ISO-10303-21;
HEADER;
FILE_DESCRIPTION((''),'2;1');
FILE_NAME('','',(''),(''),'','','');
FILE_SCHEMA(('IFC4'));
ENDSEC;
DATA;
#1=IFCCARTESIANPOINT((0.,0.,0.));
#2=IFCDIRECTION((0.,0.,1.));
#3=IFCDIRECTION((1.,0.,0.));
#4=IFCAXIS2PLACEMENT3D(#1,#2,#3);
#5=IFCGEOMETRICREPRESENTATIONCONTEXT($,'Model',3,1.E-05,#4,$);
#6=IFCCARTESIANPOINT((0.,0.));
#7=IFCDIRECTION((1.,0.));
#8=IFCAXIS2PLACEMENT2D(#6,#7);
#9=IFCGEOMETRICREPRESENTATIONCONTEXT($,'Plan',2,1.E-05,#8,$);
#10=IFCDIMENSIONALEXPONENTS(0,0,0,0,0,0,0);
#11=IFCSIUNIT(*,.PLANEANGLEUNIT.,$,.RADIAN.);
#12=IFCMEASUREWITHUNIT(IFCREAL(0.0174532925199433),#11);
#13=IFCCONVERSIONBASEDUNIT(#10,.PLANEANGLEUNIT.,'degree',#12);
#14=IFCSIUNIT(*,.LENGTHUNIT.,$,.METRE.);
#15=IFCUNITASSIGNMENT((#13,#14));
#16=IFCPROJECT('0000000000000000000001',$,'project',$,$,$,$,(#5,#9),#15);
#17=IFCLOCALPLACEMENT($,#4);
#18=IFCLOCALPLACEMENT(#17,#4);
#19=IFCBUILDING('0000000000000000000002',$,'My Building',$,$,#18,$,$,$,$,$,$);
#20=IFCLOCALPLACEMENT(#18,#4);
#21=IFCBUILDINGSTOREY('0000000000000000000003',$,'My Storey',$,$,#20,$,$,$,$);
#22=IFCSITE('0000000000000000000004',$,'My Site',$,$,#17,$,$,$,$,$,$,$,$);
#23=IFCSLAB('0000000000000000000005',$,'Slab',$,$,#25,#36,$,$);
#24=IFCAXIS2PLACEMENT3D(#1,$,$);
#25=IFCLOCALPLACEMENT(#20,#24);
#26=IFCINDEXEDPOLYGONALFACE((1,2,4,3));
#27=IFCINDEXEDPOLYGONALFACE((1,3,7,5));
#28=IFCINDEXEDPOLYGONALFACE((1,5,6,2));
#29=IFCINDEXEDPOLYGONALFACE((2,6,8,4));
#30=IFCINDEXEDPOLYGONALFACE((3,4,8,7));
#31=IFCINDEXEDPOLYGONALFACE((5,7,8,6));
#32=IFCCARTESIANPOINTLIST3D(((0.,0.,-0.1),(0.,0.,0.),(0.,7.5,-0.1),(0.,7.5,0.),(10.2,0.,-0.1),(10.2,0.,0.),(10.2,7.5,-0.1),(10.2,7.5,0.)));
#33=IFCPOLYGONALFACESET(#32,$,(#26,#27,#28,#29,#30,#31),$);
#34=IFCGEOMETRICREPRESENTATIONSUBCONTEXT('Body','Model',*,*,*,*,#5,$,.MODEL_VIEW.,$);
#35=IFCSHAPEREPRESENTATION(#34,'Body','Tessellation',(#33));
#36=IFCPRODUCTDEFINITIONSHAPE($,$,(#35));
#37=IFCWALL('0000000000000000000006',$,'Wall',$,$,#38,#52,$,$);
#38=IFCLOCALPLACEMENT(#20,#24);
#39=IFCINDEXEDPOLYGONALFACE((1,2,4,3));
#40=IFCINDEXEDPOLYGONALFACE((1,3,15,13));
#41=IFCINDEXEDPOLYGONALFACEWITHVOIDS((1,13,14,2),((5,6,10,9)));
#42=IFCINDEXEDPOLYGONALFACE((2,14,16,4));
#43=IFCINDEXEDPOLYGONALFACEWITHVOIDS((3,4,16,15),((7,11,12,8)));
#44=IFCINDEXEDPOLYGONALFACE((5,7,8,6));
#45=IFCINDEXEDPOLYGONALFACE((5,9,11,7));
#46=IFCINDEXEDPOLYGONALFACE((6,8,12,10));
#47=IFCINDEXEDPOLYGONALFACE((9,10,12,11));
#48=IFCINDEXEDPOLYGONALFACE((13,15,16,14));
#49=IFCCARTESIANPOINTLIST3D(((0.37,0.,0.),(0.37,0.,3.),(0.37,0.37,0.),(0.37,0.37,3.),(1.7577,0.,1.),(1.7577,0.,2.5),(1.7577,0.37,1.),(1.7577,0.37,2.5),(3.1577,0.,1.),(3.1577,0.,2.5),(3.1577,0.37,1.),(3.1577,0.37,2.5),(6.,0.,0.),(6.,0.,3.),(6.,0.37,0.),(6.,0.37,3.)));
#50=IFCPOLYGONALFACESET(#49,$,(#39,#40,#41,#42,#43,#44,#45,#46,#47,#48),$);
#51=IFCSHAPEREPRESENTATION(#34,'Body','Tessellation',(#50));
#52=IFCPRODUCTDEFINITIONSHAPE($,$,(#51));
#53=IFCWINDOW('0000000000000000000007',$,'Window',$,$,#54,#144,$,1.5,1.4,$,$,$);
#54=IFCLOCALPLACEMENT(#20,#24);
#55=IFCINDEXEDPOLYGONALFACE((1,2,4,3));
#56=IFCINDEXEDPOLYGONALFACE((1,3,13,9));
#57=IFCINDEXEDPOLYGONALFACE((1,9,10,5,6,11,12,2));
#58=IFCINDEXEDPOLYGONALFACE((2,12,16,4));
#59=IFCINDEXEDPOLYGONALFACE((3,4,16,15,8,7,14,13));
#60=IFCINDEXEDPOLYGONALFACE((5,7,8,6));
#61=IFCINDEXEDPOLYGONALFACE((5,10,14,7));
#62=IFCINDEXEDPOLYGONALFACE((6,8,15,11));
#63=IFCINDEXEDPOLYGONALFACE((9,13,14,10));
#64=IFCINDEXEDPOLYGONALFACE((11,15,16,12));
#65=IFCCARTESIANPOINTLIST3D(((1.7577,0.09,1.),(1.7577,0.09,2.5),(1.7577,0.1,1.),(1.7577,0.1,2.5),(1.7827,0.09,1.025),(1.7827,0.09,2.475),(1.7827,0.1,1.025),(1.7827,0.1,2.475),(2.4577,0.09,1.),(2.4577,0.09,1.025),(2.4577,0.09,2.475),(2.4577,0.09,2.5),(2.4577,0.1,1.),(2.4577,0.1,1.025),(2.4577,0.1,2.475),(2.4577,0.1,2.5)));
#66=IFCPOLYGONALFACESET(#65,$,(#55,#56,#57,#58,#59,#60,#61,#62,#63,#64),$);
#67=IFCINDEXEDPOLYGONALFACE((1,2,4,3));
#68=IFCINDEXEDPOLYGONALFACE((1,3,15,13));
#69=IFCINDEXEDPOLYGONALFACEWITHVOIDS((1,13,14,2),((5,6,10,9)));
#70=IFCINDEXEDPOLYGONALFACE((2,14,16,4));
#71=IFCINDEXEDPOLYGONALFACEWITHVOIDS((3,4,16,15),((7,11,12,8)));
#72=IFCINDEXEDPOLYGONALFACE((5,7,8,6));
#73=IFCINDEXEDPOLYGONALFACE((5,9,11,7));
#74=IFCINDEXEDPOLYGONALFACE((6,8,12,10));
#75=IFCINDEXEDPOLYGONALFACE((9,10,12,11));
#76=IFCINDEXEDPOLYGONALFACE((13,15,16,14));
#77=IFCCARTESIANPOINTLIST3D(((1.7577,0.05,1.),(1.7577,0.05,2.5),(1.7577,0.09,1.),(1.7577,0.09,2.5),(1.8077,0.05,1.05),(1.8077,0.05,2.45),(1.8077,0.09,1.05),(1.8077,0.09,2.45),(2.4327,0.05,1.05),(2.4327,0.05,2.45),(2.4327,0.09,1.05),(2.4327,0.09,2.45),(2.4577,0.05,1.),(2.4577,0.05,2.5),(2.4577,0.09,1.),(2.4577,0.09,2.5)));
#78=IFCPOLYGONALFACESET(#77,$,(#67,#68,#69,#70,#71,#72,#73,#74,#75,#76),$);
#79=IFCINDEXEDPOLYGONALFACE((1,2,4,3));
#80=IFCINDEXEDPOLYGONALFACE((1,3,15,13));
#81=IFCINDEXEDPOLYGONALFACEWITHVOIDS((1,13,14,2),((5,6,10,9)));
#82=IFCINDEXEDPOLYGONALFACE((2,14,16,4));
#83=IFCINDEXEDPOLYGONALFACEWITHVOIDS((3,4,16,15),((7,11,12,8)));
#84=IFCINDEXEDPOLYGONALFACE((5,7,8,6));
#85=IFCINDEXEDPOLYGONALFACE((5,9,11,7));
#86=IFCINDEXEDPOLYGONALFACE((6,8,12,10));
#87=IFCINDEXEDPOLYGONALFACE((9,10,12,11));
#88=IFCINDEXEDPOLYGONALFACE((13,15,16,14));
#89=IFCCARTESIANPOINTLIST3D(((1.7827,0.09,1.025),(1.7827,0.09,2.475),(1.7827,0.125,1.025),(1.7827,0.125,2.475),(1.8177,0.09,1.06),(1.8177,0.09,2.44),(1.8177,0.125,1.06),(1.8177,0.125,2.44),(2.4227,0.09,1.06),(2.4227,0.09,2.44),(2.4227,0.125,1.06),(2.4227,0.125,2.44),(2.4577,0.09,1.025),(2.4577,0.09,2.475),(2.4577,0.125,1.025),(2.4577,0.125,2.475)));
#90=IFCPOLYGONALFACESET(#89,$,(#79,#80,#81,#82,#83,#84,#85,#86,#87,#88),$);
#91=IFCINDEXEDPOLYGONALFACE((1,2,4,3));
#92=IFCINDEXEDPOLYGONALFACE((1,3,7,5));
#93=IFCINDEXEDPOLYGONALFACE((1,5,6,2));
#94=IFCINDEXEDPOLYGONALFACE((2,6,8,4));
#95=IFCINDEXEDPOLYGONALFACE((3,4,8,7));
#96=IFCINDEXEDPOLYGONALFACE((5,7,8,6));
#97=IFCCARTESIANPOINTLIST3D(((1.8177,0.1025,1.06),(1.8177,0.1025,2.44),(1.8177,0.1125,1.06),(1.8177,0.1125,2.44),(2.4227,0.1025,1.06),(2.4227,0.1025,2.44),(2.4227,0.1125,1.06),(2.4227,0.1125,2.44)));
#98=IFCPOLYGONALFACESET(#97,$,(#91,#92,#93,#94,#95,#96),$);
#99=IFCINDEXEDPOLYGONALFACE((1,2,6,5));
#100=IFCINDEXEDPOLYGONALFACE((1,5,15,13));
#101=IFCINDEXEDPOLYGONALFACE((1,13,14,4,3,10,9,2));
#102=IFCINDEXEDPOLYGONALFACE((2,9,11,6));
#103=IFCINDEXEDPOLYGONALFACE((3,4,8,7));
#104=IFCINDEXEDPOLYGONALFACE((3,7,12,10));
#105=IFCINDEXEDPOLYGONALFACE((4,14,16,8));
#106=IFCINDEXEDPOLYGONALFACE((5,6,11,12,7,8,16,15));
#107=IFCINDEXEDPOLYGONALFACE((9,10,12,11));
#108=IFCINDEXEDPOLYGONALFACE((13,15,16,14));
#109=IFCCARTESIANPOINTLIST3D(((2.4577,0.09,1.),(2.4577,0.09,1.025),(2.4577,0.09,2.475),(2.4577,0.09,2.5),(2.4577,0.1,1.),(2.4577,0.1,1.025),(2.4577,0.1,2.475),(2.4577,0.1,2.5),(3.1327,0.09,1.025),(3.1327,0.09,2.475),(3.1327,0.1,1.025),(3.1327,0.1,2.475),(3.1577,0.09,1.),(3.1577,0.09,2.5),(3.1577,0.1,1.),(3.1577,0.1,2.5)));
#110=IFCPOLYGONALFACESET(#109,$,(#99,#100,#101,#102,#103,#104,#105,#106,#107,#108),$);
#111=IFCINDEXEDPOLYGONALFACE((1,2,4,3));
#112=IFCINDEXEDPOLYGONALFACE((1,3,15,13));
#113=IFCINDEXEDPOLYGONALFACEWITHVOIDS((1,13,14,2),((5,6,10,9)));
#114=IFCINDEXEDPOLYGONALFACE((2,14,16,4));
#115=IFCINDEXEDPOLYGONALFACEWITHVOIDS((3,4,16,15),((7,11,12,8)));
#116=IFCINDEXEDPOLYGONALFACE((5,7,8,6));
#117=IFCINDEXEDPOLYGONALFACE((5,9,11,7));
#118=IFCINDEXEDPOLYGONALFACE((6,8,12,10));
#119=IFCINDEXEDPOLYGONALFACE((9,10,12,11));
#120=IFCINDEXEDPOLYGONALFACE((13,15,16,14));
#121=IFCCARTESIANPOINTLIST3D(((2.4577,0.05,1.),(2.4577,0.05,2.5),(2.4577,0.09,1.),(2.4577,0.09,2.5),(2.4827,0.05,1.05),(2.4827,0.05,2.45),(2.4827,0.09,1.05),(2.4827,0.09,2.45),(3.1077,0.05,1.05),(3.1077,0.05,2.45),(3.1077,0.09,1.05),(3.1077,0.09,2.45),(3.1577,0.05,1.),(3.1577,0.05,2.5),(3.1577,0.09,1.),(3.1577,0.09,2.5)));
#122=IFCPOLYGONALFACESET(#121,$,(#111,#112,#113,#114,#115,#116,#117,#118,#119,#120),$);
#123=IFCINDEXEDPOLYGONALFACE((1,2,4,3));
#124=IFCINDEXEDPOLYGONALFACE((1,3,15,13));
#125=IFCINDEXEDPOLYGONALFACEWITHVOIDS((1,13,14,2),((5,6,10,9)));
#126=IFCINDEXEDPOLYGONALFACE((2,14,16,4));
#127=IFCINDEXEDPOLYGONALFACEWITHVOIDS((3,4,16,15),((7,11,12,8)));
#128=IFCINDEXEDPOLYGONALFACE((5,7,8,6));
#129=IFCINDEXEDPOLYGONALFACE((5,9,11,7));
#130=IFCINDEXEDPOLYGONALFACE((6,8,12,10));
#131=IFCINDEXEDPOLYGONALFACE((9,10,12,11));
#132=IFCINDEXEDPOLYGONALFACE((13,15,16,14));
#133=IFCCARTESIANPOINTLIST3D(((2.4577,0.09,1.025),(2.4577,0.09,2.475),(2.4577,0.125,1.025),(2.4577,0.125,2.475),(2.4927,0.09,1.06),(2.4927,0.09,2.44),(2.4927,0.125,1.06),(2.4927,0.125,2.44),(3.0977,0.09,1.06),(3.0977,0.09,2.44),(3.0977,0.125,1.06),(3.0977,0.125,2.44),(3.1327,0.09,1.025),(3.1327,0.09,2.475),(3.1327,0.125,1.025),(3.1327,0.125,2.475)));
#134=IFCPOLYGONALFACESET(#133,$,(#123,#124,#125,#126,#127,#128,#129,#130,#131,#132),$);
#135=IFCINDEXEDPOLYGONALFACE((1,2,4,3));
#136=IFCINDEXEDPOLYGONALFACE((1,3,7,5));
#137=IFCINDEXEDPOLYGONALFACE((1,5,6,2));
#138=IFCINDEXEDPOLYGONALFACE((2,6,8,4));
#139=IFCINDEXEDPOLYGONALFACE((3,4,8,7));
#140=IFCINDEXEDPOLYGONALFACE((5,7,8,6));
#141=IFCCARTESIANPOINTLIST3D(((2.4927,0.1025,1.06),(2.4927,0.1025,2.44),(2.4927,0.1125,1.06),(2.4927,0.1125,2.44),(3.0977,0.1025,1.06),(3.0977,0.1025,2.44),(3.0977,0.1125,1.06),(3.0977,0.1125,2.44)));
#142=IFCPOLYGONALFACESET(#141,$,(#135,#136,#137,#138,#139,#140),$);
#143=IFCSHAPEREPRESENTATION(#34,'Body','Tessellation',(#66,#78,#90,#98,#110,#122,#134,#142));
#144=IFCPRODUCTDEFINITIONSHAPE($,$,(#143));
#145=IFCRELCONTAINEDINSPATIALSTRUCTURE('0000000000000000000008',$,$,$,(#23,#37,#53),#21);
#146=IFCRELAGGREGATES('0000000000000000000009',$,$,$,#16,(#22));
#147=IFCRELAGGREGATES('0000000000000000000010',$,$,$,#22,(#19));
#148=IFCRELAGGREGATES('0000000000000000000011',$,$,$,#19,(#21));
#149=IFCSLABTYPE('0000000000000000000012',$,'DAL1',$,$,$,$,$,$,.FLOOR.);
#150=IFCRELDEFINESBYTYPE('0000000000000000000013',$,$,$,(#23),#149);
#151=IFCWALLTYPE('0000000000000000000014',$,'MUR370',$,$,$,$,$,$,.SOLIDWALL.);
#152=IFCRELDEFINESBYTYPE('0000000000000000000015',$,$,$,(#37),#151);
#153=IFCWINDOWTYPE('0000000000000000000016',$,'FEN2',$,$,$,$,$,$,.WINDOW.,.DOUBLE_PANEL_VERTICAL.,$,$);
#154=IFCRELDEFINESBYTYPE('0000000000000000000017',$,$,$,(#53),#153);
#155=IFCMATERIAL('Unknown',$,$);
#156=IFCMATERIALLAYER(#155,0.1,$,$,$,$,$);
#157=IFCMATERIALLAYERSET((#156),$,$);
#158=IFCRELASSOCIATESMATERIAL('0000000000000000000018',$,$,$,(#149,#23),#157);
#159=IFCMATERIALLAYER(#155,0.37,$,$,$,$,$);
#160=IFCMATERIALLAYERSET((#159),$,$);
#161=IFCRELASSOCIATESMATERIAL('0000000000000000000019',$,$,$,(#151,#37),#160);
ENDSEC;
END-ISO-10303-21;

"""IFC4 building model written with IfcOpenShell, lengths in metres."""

from ifc_helpers import new_model, entity, si_unit, converted_unit, frame, origin_with_axes, origin_2d_with_axis, place, context, subcontext, project, spatial, line, indexed_curve, outline, extrude, shape, source, transform, mapped, material, layer, layer_set, layer_usage, type_object, type_shapes, element, fill, save


model = new_model("IFC4")

# Units and contexts
model_context = context("Model", 3, precision=1e-05, world=origin_with_axes())
plan_context = context("Plan", 2, precision=1e-05, world=origin_2d_with_axis())
body_context_1 = subcontext(model_context, "Body", "Model", "MODEL_VIEW")
body_context_2 = subcontext(plan_context, "Body", "Plan", "PLAN_VIEW")
ifc_project = project(units=[converted_unit("PLANEANGLEUNIT", "degree", entity("IfcReal", 0.0174532925199433), si_unit("PLANEANGLEUNIT", "RADIAN"), dimensions=[0, 0, 0, 0, 0, 0, 0]), si_unit("LENGTHUNIT", "METRE")], contexts=[model_context, plan_context])

# Site, building, storey
site_placement = place(None, origin_with_axes())
site = spatial("IfcSite", under=ifc_project, at=site_placement, Name="My Site")
building_placement = place(site_placement, origin_with_axes())
building = spatial("IfcBuilding", under=site, at=building_placement, Name="My Building")
storey_placement = place(building_placement, origin_with_axes())
storey = spatial("IfcBuildingStorey", under=building, at=storey_placement, Name="My Storey")

# Slab
ifc_material = material(Name="Unknown")
ifc_layer_1 = layer(ifc_material, 0.1)
ifc_layer_set_1 = layer_set([ifc_layer_1])
ifc_layer_usage_1 = layer_usage(ifc_layer_set_1, "AXIS3", "POSITIVE", 0.0)
slab_type = type_object("IfcSlabType", Name="DAL1", PredefinedType="FLOOR", material=ifc_layer_set_1)
slab_placement = place(storey_placement, frame((0.0, 0.0, -0.1), z_axis=(0.0, 0.0, 1.0), x_axis=(1.0, 0.0, 0.0)))
element("IfcSlab", 1, at=slab_placement, inside=storey, type_object=slab_type, material=ifc_layer_usage_1, Name="Slab", context=body_context_1, shape_type="SweptSolid", body=[
    extrude(outline(indexed_curve([(0.0, 0.0), (10.2, 0.0), (10.2, 7.5), (0.0, 7.5)], segments=[line(4, 1), line(1, 2), line(2, 3), line(3, 4)], self_intersect=False)), None, (0.0, 0.0, 1.0), 0.1),
])

# Wall, opening, window
ifc_layer_2 = layer(ifc_material, 0.37)
ifc_layer_set_2 = layer_set([ifc_layer_2])
ifc_layer_usage_2 = layer_usage(ifc_layer_set_2, "AXIS2", "POSITIVE", 0.0)
wall_type_1 = type_object("IfcWallType", Name="MUR370", PredefinedType="SOLIDWALL", material=ifc_layer_set_2)
wall_1_placement = place(storey_placement, frame((0.37, 0.0, 0.0), z_axis=(0.0, 0.0, 1.0), x_axis=(1.0, 0.0, 0.0)))
wall_1 = element("IfcWall", 2, at=wall_1_placement, inside=storey, type_object=wall_type_1, material=ifc_layer_usage_2, Name="Wall", context=body_context_1, shape_type="SweptSolid", body=[
    extrude(outline(indexed_curve([(0.0, 0.0), (0.0, 0.37), (5.63, 0.37), (5.63, 0.0), (0.0, 0.0)], self_intersect=False)), origin_with_axes(), (0.0, 0.0, 1.0), 3.0),
])
shared_shape_1 = source(origin_with_axes(), body_context_1, "Body", "SweptSolid", [
    extrude(outline(indexed_curve([(0.0, 0.0), (1.4, 0.0), (1.4, 1.5), (0.0, 1.5)], segments=[line(1, 2, 3, 4, 1)])), frame((0.0, -0.6, 0.0), z_axis=(0.0, -1.0, 0.0), x_axis=(1.0, 0.0, 0.0)), (0.0, 0.0, -1.0), 1.2),
])
opening_1_placement = place(wall_1_placement, frame((1.3877, 0.0, 1.0), z_axis=(0.0, 0.0, 1.0), x_axis=(1.0, 0.0, 0.0)))
opening_1 = element("IfcOpeningElement", 3, at=opening_1_placement, cuts=wall_1, PredefinedType="OPENING", context=body_context_1, shape_type="MappedRepresentation", body=[
    mapped(shared_shape_1, transform((0.0, 0.0, 0.0), x_axis=(1.0, 0.0, 0.0), y_axis=(0.0, 1.0, 0.0), z_axis=(0.0, 0.0, 1.0), scale=1.0)),
])
window_type_1 = type_object("IfcWindowType", Name="FEN2", PartitioningType="DOUBLE_PANEL_VERTICAL", PredefinedType="WINDOW")
shared_shape_2 = source(origin_with_axes(), body_context_1, "Body", "SweptSolid", [
    extrude(outline(indexed_curve([(0.7, 0.0), (0.0, 0.0), (0.0, 1.5), (0.7, 1.5), (0.7, 1.475), (0.025, 1.475), (0.025, 0.025), (0.7, 0.025)], segments=[line(1, 2, 3, 4, 5, 6, 7, 8, 1)])), frame((0.0, 0.09, 0.0), z_axis=(0.0, -1.0, 0.0), x_axis=(1.0, 0.0, 0.0)), (0.0, 0.0, -1.0), 0.01),
    extrude(outline(indexed_curve([(0.0, 0.0), (0.7, 0.0), (0.7, 1.5), (0.0, 1.5)], segments=[line(1, 2, 3, 4, 1)]), holes=[indexed_curve([(0.05, 0.05), (0.675, 0.05), (0.675, 1.45), (0.05, 1.45)], segments=[line(1, 2, 3, 4, 1)])]), frame((0.0, 0.05, 0.0), z_axis=(0.0, -1.0, 0.0), x_axis=(1.0, 0.0, 0.0)), (0.0, 0.0, -1.0), 0.04),
    extrude(outline(indexed_curve([(0.0, 0.0), (0.675, 0.0), (0.675, 1.45), (0.0, 1.45)], segments=[line(1, 2, 3, 4, 1)]), holes=[indexed_curve([(0.035, 0.035), (0.64, 0.035), (0.64, 1.415), (0.035, 1.415)], segments=[line(1, 2, 3, 4, 1)])]), frame((0.025, 0.09, 0.025), z_axis=(0.0, -1.0, 0.0), x_axis=(1.0, 0.0, 0.0)), (0.0, 0.0, -1.0), 0.035),
    extrude(outline(indexed_curve([(0.035, 0.035), (0.64, 0.035), (0.64, 1.415), (0.035, 1.415)], segments=[line(1, 2, 3, 4, 1)])), frame((0.025, 0.1025, 0.025), z_axis=(0.0, -1.0, 0.0), x_axis=(1.0, 0.0, 0.0)), (0.0, 0.0, -1.0), 0.01),
    extrude(outline(indexed_curve([(0.0, 1.5), (0.7, 1.5), (0.7, 0.0), (0.0, 0.0), (0.0, 0.025), (0.675, 0.025), (0.675, 1.475), (0.0, 1.475)], segments=[line(1, 2, 3, 4, 5, 6, 7, 8, 1)])), frame((0.7, 0.09, 0.0), z_axis=(0.0, -1.0, 0.0), x_axis=(1.0, 0.0, 0.0)), (0.0, 0.0, -1.0), 0.01),
    extrude(outline(indexed_curve([(0.0, 0.0), (0.7, 0.0), (0.7, 1.5), (0.0, 1.5)], segments=[line(1, 2, 3, 4, 1)]), holes=[indexed_curve([(0.025, 0.05), (0.65, 0.05), (0.65, 1.45), (0.025, 1.45)], segments=[line(1, 2, 3, 4, 1)])]), frame((0.7, 0.05, 0.0), z_axis=(0.0, -1.0, 0.0), x_axis=(1.0, 0.0, 0.0)), (0.0, 0.0, -1.0), 0.04),
    extrude(outline(indexed_curve([(0.0, 0.0), (0.675, 0.0), (0.675, 1.45), (0.0, 1.45)], segments=[line(1, 2, 3, 4, 1)]), holes=[indexed_curve([(0.035, 0.035), (0.64, 0.035), (0.64, 1.415), (0.035, 1.415)], segments=[line(1, 2, 3, 4, 1)])]), frame((0.7, 0.09, 0.025), z_axis=(0.0, -1.0, 0.0), x_axis=(1.0, 0.0, 0.0)), (0.0, 0.0, -1.0), 0.035),
    extrude(outline(indexed_curve([(0.035, 0.035), (0.64, 0.035), (0.64, 1.415), (0.035, 1.415)], segments=[line(1, 2, 3, 4, 1)])), frame((0.7, 0.1025, 0.025), z_axis=(0.0, -1.0, 0.0), x_axis=(1.0, 0.0, 0.0)), (0.0, 0.0, -1.0), 0.01),
])
shared_shape_3 = source(origin_with_axes(), body_context_2, "Body", "Curve2D", [
    entity("IfcIndexedPolyCurve", entity("IfcCartesianPointList2D", [[0.05, 0.05], [0.675, 0.05]])),
    entity("IfcIndexedPolyCurve", entity("IfcCartesianPointList2D", [[0.0, 0.1], [0.025, 0.1], [0.025, 0.09], [0.05, 0.09], [0.05, 0.05], [0.0, 0.05]]), [entity("IfcLineIndex", [1, 2, 3, 4, 5, 6, 1])]),
    entity("IfcIndexedPolyCurve", entity("IfcCartesianPointList2D", [[0.7, 0.1], [0.7, 0.1], [0.7, 0.09], [0.675, 0.09], [0.675, 0.05], [0.7, 0.05]])),
    entity("IfcIndexedPolyCurve", entity("IfcCartesianPointList2D", [[0.025, 0.09], [0.06, 0.09], [0.06, 0.125], [0.025, 0.125]]), [entity("IfcLineIndex", [1, 2, 3, 4, 1])]),
    entity("IfcIndexedPolyCurve", entity("IfcCartesianPointList2D", [[0.7, 0.09], [0.665, 0.09], [0.665, 0.125], [0.7, 0.125]]), [entity("IfcLineIndex", [1, 2, 3, 4, 1])]),
    entity("IfcIndexedPolyCurve", entity("IfcCartesianPointList2D", [[0.06, 0.09], [0.665, 0.09]])),
    entity("IfcIndexedPolyCurve", entity("IfcCartesianPointList2D", [[0.06, 0.125], [0.665, 0.125]])),
    entity("IfcIndexedPolyCurve", entity("IfcCartesianPointList2D", [[0.06, 0.1075], [0.665, 0.1075]])),
    entity("IfcIndexedPolyCurve", entity("IfcCartesianPointList2D", [[0.725, 0.05], [1.35, 0.05]])),
    entity("IfcIndexedPolyCurve", entity("IfcCartesianPointList2D", [[0.7, 0.1], [0.7, 0.1], [0.7, 0.09], [0.725, 0.09], [0.725, 0.05], [0.7, 0.05]])),
    entity("IfcIndexedPolyCurve", entity("IfcCartesianPointList2D", [[1.4, 0.1], [1.375, 0.1], [1.375, 0.09], [1.35, 0.09], [1.35, 0.05], [1.4, 0.05]]), [entity("IfcLineIndex", [1, 2, 3, 4, 5, 6, 1])]),
    entity("IfcIndexedPolyCurve", entity("IfcCartesianPointList2D", [[0.7, 0.09], [0.735, 0.09], [0.735, 0.125], [0.7, 0.125]]), [entity("IfcLineIndex", [1, 2, 3, 4, 1])]),
    entity("IfcIndexedPolyCurve", entity("IfcCartesianPointList2D", [[1.375, 0.09], [1.34, 0.09], [1.34, 0.125], [1.375, 0.125]]), [entity("IfcLineIndex", [1, 2, 3, 4, 1])]),
    entity("IfcIndexedPolyCurve", entity("IfcCartesianPointList2D", [[0.735, 0.09], [1.34, 0.09]])),
    entity("IfcIndexedPolyCurve", entity("IfcCartesianPointList2D", [[0.735, 0.125], [1.34, 0.125]])),
    entity("IfcIndexedPolyCurve", entity("IfcCartesianPointList2D", [[0.735, 0.1075], [1.34, 0.1075]])),
])
type_shapes(window_type_1, [shared_shape_2, shared_shape_3])
window_1_placement = place(opening_1_placement, origin_with_axes())
window_1 = element("IfcWindow", 4, at=window_1_placement, inside=storey, type_object=window_type_1, Name="Window", OverallHeight=1.5, OverallWidth=1.4, shapes=[
    shape(body_context_1, "Body", "MappedRepresentation", [mapped(shared_shape_2, transform((0.0, 0.0, 0.0), x_axis=(1.0, 0.0, 0.0), y_axis=(0.0, 1.0, 0.0), z_axis=(0.0, 0.0, 1.0), scale=1.0))]),
    shape(body_context_2, "Body", "MappedRepresentation", [mapped(shared_shape_3, transform((0.0, 0.0, 0.0), x_axis=(1.0, 0.0, 0.0), y_axis=(0.0, 1.0, 0.0), z_axis=(0.0, 0.0, 1.0), scale=1.0))]),
])
fill(opening_1, window_1)

save(model, "model.ifc")
